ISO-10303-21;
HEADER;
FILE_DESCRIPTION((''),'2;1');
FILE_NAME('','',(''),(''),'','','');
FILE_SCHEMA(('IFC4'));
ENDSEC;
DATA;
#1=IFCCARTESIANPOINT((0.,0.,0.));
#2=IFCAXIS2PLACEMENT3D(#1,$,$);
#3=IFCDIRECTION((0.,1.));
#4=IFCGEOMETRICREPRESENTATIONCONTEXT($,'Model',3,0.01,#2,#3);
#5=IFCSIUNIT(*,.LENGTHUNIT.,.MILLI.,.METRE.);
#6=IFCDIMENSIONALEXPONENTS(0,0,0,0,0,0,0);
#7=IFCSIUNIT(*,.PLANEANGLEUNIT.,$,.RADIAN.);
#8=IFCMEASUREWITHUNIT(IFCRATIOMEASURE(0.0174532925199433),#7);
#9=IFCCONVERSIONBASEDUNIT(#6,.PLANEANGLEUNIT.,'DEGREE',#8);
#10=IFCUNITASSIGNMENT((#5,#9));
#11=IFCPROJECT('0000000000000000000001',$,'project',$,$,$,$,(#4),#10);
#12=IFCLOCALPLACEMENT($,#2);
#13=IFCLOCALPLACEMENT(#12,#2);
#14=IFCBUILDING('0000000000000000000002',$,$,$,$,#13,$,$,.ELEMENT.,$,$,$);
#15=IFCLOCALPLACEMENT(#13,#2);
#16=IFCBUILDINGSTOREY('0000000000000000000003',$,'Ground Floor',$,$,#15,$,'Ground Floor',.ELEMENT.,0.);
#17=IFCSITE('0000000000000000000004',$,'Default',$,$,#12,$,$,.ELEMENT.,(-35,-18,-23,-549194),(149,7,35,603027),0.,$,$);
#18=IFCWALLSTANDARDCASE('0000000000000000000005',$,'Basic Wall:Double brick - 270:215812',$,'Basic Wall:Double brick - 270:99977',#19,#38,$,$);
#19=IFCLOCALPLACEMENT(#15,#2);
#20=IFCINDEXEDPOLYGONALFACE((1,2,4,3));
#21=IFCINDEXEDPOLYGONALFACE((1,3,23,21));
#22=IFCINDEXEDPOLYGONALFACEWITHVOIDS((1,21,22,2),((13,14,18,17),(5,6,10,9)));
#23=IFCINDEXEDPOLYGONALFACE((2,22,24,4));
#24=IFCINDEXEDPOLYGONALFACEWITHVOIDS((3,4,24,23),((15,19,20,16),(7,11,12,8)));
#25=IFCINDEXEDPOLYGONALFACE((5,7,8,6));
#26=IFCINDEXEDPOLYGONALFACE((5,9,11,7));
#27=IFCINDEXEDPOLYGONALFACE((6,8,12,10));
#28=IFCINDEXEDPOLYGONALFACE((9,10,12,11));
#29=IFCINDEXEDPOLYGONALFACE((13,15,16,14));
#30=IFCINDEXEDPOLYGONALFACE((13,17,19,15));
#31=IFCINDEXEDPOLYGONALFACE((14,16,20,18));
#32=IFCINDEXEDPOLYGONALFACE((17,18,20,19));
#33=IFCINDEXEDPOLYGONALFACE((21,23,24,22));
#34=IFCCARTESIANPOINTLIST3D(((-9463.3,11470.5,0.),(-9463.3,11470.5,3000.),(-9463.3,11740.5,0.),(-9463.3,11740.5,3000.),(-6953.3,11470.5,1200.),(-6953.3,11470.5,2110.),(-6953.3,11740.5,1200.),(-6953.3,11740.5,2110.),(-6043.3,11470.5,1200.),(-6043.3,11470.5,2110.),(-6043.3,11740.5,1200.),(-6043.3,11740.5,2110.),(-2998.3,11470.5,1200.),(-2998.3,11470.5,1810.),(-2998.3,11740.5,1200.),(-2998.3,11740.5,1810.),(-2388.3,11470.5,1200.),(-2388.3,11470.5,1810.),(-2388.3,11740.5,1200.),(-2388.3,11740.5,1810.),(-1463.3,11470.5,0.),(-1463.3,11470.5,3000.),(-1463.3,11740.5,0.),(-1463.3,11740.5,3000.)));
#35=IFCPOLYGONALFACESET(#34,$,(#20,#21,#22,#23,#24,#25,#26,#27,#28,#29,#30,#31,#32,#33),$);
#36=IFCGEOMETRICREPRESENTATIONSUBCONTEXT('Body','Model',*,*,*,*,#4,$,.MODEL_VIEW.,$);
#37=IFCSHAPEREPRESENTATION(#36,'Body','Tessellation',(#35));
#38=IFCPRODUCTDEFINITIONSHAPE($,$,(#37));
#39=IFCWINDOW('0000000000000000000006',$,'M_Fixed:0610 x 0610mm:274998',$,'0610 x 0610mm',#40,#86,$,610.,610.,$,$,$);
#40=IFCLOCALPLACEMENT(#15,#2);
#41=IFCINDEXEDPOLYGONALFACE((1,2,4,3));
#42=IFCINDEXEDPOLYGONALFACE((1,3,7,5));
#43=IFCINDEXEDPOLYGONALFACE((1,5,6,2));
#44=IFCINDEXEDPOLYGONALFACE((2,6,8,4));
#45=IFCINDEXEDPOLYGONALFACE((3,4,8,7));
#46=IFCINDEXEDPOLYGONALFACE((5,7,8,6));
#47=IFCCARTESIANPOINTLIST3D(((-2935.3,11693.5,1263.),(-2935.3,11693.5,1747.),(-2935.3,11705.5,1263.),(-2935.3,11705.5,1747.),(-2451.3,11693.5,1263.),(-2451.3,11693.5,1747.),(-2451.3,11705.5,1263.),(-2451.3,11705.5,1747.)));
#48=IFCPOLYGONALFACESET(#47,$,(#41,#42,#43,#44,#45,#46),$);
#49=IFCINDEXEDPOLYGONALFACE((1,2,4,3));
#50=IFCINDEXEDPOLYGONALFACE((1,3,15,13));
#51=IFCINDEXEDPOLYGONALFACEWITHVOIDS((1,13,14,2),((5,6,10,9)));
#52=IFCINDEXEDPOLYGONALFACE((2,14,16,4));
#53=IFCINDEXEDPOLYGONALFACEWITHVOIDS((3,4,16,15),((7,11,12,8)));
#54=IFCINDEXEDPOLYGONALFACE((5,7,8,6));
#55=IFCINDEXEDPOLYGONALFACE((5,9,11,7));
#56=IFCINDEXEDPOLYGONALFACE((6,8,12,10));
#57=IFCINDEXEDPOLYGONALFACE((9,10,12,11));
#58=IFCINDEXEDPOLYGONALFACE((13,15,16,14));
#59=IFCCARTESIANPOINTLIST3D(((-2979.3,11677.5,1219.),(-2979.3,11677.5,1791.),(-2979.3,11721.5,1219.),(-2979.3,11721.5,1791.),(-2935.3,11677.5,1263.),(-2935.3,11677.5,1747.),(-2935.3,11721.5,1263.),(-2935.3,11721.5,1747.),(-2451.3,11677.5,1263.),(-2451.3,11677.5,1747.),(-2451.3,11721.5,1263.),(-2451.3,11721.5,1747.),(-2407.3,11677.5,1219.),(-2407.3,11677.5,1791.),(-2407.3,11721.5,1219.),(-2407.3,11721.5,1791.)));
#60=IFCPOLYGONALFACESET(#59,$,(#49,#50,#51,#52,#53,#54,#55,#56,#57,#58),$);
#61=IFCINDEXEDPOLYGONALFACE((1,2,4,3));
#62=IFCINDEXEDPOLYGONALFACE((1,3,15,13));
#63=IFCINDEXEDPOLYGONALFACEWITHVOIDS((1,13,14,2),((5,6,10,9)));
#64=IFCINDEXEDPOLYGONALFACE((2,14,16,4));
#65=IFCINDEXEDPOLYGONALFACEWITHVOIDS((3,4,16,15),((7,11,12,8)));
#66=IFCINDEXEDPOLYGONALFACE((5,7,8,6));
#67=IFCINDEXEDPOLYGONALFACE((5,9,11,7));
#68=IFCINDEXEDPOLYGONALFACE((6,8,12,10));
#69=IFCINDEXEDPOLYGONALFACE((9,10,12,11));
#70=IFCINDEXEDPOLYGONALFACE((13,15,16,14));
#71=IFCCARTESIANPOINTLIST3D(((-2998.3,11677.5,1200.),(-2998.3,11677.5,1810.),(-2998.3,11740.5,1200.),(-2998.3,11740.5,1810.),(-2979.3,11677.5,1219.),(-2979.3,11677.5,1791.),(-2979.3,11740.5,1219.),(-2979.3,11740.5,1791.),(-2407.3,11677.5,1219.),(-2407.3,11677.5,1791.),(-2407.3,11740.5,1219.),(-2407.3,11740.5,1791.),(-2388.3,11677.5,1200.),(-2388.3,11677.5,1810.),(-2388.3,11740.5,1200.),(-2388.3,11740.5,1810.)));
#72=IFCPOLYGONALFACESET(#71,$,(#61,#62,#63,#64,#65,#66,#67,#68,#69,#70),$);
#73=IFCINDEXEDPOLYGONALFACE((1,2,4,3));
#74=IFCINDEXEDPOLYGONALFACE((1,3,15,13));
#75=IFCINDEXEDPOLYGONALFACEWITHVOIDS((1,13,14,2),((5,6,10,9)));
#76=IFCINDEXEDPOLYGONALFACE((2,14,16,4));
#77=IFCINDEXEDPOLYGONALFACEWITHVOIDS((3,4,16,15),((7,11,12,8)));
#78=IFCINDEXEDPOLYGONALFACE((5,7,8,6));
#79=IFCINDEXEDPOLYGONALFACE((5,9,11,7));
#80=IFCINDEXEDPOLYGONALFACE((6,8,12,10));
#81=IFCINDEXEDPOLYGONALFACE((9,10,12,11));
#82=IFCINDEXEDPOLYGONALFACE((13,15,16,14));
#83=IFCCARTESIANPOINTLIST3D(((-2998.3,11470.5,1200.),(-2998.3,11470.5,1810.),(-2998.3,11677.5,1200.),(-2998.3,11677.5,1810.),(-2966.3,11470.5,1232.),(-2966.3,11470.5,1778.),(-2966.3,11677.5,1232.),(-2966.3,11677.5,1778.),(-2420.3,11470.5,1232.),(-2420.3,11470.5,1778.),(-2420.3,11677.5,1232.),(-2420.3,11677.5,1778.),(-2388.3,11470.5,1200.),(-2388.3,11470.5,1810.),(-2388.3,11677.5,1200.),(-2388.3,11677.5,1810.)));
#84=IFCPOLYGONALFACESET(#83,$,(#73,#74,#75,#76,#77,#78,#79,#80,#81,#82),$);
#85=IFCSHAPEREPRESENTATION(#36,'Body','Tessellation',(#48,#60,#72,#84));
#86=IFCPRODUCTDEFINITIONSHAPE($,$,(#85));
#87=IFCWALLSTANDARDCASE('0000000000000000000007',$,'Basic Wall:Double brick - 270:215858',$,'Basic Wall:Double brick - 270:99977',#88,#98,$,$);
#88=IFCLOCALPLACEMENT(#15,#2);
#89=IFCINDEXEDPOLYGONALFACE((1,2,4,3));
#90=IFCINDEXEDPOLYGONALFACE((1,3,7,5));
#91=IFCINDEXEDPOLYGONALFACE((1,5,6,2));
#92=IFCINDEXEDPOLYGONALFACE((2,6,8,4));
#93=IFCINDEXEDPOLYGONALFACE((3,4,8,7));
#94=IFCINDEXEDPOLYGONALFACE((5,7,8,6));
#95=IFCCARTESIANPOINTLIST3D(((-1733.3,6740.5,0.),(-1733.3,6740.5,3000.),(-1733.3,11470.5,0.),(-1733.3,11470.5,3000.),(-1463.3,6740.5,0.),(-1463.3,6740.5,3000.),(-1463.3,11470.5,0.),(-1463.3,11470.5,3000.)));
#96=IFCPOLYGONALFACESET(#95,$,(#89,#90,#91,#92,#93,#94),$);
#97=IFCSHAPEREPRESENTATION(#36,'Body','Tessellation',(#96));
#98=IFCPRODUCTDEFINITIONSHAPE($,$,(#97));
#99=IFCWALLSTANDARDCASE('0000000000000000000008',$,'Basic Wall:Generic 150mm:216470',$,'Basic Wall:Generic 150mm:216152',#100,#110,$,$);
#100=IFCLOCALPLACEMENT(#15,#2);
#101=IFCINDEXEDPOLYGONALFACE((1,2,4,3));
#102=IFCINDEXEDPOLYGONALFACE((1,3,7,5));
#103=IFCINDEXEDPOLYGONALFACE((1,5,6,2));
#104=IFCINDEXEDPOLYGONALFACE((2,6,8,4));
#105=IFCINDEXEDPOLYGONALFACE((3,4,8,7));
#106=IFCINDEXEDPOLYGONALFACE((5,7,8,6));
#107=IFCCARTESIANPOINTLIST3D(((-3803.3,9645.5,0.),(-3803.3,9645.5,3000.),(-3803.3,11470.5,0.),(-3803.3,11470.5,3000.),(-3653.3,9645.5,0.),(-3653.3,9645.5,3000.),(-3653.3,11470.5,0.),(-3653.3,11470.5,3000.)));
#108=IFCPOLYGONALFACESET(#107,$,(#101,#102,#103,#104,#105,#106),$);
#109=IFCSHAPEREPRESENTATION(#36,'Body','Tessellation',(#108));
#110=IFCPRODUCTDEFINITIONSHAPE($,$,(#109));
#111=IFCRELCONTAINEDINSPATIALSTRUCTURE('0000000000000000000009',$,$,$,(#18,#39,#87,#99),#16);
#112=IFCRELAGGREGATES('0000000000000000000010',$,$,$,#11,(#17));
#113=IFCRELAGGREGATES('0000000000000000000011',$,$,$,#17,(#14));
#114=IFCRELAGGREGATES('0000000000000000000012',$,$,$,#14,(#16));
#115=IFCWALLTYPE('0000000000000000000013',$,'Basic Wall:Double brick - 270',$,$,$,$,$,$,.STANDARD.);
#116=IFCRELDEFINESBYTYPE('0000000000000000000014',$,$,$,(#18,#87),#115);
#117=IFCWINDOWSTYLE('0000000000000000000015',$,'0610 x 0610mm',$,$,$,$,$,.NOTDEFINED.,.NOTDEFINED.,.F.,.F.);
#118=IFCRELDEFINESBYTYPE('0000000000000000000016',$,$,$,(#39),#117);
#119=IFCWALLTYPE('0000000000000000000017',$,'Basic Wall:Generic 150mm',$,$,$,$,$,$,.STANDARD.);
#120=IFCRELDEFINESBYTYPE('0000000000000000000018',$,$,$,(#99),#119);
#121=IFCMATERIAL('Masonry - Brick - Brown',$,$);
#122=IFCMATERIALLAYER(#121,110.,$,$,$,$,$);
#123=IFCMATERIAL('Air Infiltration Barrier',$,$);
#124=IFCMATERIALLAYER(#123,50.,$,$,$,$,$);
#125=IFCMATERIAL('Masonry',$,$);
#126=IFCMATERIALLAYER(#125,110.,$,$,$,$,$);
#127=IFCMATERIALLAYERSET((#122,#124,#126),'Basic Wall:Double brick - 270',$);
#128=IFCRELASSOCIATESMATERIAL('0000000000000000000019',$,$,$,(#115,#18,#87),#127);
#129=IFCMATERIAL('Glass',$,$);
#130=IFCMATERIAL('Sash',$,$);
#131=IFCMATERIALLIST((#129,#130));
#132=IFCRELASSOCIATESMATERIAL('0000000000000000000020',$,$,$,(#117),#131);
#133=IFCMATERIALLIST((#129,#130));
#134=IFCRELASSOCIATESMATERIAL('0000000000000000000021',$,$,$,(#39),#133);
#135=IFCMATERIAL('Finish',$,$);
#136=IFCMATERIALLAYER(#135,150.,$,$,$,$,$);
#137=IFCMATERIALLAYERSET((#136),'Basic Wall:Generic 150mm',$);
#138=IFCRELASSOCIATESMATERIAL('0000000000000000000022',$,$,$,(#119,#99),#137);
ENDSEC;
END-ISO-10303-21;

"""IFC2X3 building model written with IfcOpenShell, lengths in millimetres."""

from ifc_helpers import new_model, entity, si_unit, converted_unit, direction, frame, frame_2d, origin, place, context, subcontext, project, spatial, polyline, rectangle, outline, extrude, source, transform, mapped, material, material_list, layer, layer_set, layer_usage, type_object, type_shapes, element, fill, save


model = new_model("IFC2X3")

# Units and contexts
model_context = context("Model", 3, precision=0.01, world=origin(), true_north=direction((0.0, 1.0)))
body_context = subcontext(model_context, "Body", "Model", "MODEL_VIEW")
ifc_project = project(units=[si_unit("LENGTHUNIT", "METRE", prefix="MILLI"), converted_unit("PLANEANGLEUNIT", "DEGREE", entity("IfcRatioMeasure", 0.0174532925199433), si_unit("PLANEANGLEUNIT", "RADIAN"), dimensions=[0, 0, 0, 0, 0, 0, 0])], contexts=[model_context])

# Site, building, storey
site_placement = place(None, origin())
site = spatial("IfcSite", under=ifc_project, at=site_placement, Name="Default", CompositionType="ELEMENT", RefLatitude=(-35, -18, -23, -549194), RefLongitude=(149, 7, 35, 603027), RefElevation=0.0)
building_placement = place(site_placement, origin())
building = spatial("IfcBuilding", under=site, at=building_placement, CompositionType="ELEMENT")
storey_placement = place(building_placement, origin())
storey = spatial("IfcBuildingStorey", under=building, at=storey_placement, Name="Ground Floor", LongName="Ground Floor", CompositionType="ELEMENT", Elevation=0.0)

# Wall, openings, window
ifc_material_1 = material(Name="Masonry - Brick - Brown")
ifc_layer_1 = layer(ifc_material_1, 110.0)
ifc_material_2 = material(Name="Air Infiltration Barrier")
ifc_layer_2 = layer(ifc_material_2, 50.0)
ifc_material_3 = material(Name="Masonry")
ifc_layer_3 = layer(ifc_material_3, 110.0)
ifc_layer_set_1 = layer_set([ifc_layer_1, ifc_layer_2, ifc_layer_3], Name="Basic Wall:Double brick - 270")
ifc_layer_usage_1 = layer_usage(ifc_layer_set_1, "AXIS2", "NEGATIVE", 135.0)
wall_type_1 = type_object("IfcWallType", Name="Basic Wall:Double brick - 270", PredefinedType="STANDARD", material=ifc_layer_set_1)
wall_1_placement = place(storey_placement, frame((-9463.3, 11605.5, 0.0)))
wall_1 = element("IfcWallStandardCase", 1, at=wall_1_placement, inside=storey, type_object=wall_type_1, material=ifc_layer_usage_1, Name="Basic Wall:Double brick - 270:215812", ObjectType="Basic Wall:Double brick - 270:99977", context=body_context, shape_type="SweptSolid", body=[
    extrude(rectangle(XDim=8000.0, YDim=270.0, at=frame_2d((4000.0, 0.0), x_axis=(-1.0, 0.0))), origin(), (0.0, 0.0, 1.0), 3000.0),
])
opening_1_placement = place(wall_1_placement, frame((6465.0, -135.0, 1200.0)))
opening_1 = element("IfcOpeningElement", 2, at=opening_1_placement, cuts=wall_1, ObjectType="Opening", context=body_context, shape_type="SweptSolid", body=[
    extrude(rectangle(XDim=610.0, YDim=610.0, at=frame_2d((305.0, 305.0), x_axis=(1.0, 0.0))), frame((0.0, 0.0, 0.0), z_axis=(0.0, 1.0, 0.0), x_axis=(0.0, 0.0, 1.0)), (0.0, 0.0, 1.0), 270.0),
])
opening_2_placement = place(wall_1_placement, frame((2510.0, -135.0, 1200.0)))
element("IfcOpeningElement", 3, at=opening_2_placement, cuts=wall_1, ObjectType="Opening", context=body_context, shape_type="SweptSolid", body=[
    extrude(rectangle(XDim=910.0, YDim=910.0, at=frame_2d((455.0, 455.0), x_axis=(-1.0, 0.0))), frame((0.0, 0.0, 0.0), z_axis=(0.0, 1.0, 0.0), x_axis=(0.0, 0.0, 1.0)), (0.0, 0.0, 1.0), 270.0),
])
ifc_material_4 = material(Name="Glass")
ifc_material_5 = material(Name="Sash")
ifc_material_list_1 = material_list([ifc_material_4, ifc_material_5])
ifc_material_list_2 = material_list([ifc_material_4, ifc_material_5])
window_style = type_object("IfcWindowStyle", Name="0610 x 0610mm", ConstructionType="NOTDEFINED", OperationType="NOTDEFINED", ParameterTakesPrecedence=False, Sizeable=False, material=ifc_material_list_2)
shared_shape = source(origin(), body_context, "Body", "SweptSolid", [
    extrude(rectangle(XDim=12.0, YDim=484.0, at=frame_2d((0.0, 0.0), x_axis=(1.0, 0.0))), frame((305.0, 229.0, 63.0), z_axis=(0.0, 0.0, 1.0), x_axis=(0.0, -1.0, 0.0)), (0.0, 0.0, 1.0), 484.0),
    extrude(outline(polyline([(-286.0, -286.0), (286.0, -286.0), (286.0, 286.0), (-286.0, 286.0), (-286.0, -286.0)]), holes=[polyline([(-242.0, -242.0), (-242.0, 242.0), (242.0, 242.0), (242.0, -242.0), (-242.0, -242.0)])]), frame((305.0, 207.0, 305.0), z_axis=(0.0, 1.0, 0.0), x_axis=(1.0, 0.0, 0.0)), (0.0, 0.0, 1.0), 44.0),
    extrude(outline(polyline([(-305.0, -305.0), (305.0, -305.0), (305.0, 305.0), (-305.0, 305.0), (-305.0, -305.0)]), holes=[polyline([(-286.0, -286.0), (-286.0, 286.0), (286.0, 286.0), (286.0, -286.0), (-286.0, -286.0)])]), frame((305.0, 207.0, 305.0), z_axis=(0.0, 1.0, 0.0), x_axis=(1.0, 0.0, 0.0)), (0.0, 0.0, 1.0), 63.0),
    extrude(outline(polyline([(-305.0, -305.0), (305.0, -305.0), (305.0, 305.0), (-305.0, 305.0), (-305.0, -305.0)]), holes=[polyline([(-273.0, -273.0), (-273.0, 273.0), (273.0, 273.0), (273.0, -273.0), (-273.0, -273.0)])]), frame((305.0, 0.0, 305.0), z_axis=(0.0, 1.0, 0.0), x_axis=(1.0, 0.0, 0.0)), (0.0, 0.0, 1.0), 207.0),
])
type_shapes(window_style, [shared_shape])
window_placement = place(opening_1_placement, origin())
window = element("IfcWindow", 4, at=window_placement, inside=storey, type_object=window_style, material=ifc_material_list_1, Name="M_Fixed:0610 x 0610mm:274998", ObjectType="0610 x 0610mm", OverallHeight=610.0, OverallWidth=610.0, context=body_context, shape_type="MappedRepresentation", body=[
    mapped(shared_shape, transform((0.0, 0.0, 0.0), scale=1.0)),
])
fill(opening_1, window)

# Walls
ifc_layer_usage_2 = layer_usage(ifc_layer_set_1, "AXIS2", "NEGATIVE", 135.0)
wall_2_placement = place(storey_placement, frame((-1598.3, 11470.5, 0.0), z_axis=(0.0, 0.0, 1.0), x_axis=(0.0, -1.0, 0.0)))
element("IfcWallStandardCase", 5, at=wall_2_placement, inside=storey, type_object=wall_type_1, material=ifc_layer_usage_2, Name="Basic Wall:Double brick - 270:215858", ObjectType="Basic Wall:Double brick - 270:99977", context=body_context, shape_type="SweptSolid", body=[
    extrude(rectangle(XDim=4730.0, YDim=270.0, at=frame_2d((2365.0, 0.0), x_axis=(-1.0, 0.0))), origin(), (0.0, 0.0, 1.0), 3000.0),
])
ifc_material_6 = material(Name="Finish")
ifc_layer_4 = layer(ifc_material_6, 150.0)
ifc_layer_set_2 = layer_set([ifc_layer_4], Name="Basic Wall:Generic 150mm")
ifc_layer_usage_3 = layer_usage(ifc_layer_set_2, "AXIS2", "NEGATIVE", 75.0)
wall_type_2 = type_object("IfcWallType", Name="Basic Wall:Generic 150mm", PredefinedType="STANDARD", material=ifc_layer_set_2)
wall_3_placement = place(storey_placement, frame((-3728.3, 9645.5, 0.0), z_axis=(0.0, 0.0, 1.0), x_axis=(0.0, 1.0, 0.0)))
element("IfcWallStandardCase", 6, at=wall_3_placement, inside=storey, type_object=wall_type_2, material=ifc_layer_usage_3, Name="Basic Wall:Generic 150mm:216470", ObjectType="Basic Wall:Generic 150mm:216152", context=body_context, shape_type="SweptSolid", body=[
    extrude(rectangle(XDim=1825.0, YDim=150.0, at=frame_2d((912.5, 0.0), x_axis=(-1.0, 0.0))), origin(), (0.0, 0.0, 1.0), 3000.0),
])

save(model, "model.ifc")
